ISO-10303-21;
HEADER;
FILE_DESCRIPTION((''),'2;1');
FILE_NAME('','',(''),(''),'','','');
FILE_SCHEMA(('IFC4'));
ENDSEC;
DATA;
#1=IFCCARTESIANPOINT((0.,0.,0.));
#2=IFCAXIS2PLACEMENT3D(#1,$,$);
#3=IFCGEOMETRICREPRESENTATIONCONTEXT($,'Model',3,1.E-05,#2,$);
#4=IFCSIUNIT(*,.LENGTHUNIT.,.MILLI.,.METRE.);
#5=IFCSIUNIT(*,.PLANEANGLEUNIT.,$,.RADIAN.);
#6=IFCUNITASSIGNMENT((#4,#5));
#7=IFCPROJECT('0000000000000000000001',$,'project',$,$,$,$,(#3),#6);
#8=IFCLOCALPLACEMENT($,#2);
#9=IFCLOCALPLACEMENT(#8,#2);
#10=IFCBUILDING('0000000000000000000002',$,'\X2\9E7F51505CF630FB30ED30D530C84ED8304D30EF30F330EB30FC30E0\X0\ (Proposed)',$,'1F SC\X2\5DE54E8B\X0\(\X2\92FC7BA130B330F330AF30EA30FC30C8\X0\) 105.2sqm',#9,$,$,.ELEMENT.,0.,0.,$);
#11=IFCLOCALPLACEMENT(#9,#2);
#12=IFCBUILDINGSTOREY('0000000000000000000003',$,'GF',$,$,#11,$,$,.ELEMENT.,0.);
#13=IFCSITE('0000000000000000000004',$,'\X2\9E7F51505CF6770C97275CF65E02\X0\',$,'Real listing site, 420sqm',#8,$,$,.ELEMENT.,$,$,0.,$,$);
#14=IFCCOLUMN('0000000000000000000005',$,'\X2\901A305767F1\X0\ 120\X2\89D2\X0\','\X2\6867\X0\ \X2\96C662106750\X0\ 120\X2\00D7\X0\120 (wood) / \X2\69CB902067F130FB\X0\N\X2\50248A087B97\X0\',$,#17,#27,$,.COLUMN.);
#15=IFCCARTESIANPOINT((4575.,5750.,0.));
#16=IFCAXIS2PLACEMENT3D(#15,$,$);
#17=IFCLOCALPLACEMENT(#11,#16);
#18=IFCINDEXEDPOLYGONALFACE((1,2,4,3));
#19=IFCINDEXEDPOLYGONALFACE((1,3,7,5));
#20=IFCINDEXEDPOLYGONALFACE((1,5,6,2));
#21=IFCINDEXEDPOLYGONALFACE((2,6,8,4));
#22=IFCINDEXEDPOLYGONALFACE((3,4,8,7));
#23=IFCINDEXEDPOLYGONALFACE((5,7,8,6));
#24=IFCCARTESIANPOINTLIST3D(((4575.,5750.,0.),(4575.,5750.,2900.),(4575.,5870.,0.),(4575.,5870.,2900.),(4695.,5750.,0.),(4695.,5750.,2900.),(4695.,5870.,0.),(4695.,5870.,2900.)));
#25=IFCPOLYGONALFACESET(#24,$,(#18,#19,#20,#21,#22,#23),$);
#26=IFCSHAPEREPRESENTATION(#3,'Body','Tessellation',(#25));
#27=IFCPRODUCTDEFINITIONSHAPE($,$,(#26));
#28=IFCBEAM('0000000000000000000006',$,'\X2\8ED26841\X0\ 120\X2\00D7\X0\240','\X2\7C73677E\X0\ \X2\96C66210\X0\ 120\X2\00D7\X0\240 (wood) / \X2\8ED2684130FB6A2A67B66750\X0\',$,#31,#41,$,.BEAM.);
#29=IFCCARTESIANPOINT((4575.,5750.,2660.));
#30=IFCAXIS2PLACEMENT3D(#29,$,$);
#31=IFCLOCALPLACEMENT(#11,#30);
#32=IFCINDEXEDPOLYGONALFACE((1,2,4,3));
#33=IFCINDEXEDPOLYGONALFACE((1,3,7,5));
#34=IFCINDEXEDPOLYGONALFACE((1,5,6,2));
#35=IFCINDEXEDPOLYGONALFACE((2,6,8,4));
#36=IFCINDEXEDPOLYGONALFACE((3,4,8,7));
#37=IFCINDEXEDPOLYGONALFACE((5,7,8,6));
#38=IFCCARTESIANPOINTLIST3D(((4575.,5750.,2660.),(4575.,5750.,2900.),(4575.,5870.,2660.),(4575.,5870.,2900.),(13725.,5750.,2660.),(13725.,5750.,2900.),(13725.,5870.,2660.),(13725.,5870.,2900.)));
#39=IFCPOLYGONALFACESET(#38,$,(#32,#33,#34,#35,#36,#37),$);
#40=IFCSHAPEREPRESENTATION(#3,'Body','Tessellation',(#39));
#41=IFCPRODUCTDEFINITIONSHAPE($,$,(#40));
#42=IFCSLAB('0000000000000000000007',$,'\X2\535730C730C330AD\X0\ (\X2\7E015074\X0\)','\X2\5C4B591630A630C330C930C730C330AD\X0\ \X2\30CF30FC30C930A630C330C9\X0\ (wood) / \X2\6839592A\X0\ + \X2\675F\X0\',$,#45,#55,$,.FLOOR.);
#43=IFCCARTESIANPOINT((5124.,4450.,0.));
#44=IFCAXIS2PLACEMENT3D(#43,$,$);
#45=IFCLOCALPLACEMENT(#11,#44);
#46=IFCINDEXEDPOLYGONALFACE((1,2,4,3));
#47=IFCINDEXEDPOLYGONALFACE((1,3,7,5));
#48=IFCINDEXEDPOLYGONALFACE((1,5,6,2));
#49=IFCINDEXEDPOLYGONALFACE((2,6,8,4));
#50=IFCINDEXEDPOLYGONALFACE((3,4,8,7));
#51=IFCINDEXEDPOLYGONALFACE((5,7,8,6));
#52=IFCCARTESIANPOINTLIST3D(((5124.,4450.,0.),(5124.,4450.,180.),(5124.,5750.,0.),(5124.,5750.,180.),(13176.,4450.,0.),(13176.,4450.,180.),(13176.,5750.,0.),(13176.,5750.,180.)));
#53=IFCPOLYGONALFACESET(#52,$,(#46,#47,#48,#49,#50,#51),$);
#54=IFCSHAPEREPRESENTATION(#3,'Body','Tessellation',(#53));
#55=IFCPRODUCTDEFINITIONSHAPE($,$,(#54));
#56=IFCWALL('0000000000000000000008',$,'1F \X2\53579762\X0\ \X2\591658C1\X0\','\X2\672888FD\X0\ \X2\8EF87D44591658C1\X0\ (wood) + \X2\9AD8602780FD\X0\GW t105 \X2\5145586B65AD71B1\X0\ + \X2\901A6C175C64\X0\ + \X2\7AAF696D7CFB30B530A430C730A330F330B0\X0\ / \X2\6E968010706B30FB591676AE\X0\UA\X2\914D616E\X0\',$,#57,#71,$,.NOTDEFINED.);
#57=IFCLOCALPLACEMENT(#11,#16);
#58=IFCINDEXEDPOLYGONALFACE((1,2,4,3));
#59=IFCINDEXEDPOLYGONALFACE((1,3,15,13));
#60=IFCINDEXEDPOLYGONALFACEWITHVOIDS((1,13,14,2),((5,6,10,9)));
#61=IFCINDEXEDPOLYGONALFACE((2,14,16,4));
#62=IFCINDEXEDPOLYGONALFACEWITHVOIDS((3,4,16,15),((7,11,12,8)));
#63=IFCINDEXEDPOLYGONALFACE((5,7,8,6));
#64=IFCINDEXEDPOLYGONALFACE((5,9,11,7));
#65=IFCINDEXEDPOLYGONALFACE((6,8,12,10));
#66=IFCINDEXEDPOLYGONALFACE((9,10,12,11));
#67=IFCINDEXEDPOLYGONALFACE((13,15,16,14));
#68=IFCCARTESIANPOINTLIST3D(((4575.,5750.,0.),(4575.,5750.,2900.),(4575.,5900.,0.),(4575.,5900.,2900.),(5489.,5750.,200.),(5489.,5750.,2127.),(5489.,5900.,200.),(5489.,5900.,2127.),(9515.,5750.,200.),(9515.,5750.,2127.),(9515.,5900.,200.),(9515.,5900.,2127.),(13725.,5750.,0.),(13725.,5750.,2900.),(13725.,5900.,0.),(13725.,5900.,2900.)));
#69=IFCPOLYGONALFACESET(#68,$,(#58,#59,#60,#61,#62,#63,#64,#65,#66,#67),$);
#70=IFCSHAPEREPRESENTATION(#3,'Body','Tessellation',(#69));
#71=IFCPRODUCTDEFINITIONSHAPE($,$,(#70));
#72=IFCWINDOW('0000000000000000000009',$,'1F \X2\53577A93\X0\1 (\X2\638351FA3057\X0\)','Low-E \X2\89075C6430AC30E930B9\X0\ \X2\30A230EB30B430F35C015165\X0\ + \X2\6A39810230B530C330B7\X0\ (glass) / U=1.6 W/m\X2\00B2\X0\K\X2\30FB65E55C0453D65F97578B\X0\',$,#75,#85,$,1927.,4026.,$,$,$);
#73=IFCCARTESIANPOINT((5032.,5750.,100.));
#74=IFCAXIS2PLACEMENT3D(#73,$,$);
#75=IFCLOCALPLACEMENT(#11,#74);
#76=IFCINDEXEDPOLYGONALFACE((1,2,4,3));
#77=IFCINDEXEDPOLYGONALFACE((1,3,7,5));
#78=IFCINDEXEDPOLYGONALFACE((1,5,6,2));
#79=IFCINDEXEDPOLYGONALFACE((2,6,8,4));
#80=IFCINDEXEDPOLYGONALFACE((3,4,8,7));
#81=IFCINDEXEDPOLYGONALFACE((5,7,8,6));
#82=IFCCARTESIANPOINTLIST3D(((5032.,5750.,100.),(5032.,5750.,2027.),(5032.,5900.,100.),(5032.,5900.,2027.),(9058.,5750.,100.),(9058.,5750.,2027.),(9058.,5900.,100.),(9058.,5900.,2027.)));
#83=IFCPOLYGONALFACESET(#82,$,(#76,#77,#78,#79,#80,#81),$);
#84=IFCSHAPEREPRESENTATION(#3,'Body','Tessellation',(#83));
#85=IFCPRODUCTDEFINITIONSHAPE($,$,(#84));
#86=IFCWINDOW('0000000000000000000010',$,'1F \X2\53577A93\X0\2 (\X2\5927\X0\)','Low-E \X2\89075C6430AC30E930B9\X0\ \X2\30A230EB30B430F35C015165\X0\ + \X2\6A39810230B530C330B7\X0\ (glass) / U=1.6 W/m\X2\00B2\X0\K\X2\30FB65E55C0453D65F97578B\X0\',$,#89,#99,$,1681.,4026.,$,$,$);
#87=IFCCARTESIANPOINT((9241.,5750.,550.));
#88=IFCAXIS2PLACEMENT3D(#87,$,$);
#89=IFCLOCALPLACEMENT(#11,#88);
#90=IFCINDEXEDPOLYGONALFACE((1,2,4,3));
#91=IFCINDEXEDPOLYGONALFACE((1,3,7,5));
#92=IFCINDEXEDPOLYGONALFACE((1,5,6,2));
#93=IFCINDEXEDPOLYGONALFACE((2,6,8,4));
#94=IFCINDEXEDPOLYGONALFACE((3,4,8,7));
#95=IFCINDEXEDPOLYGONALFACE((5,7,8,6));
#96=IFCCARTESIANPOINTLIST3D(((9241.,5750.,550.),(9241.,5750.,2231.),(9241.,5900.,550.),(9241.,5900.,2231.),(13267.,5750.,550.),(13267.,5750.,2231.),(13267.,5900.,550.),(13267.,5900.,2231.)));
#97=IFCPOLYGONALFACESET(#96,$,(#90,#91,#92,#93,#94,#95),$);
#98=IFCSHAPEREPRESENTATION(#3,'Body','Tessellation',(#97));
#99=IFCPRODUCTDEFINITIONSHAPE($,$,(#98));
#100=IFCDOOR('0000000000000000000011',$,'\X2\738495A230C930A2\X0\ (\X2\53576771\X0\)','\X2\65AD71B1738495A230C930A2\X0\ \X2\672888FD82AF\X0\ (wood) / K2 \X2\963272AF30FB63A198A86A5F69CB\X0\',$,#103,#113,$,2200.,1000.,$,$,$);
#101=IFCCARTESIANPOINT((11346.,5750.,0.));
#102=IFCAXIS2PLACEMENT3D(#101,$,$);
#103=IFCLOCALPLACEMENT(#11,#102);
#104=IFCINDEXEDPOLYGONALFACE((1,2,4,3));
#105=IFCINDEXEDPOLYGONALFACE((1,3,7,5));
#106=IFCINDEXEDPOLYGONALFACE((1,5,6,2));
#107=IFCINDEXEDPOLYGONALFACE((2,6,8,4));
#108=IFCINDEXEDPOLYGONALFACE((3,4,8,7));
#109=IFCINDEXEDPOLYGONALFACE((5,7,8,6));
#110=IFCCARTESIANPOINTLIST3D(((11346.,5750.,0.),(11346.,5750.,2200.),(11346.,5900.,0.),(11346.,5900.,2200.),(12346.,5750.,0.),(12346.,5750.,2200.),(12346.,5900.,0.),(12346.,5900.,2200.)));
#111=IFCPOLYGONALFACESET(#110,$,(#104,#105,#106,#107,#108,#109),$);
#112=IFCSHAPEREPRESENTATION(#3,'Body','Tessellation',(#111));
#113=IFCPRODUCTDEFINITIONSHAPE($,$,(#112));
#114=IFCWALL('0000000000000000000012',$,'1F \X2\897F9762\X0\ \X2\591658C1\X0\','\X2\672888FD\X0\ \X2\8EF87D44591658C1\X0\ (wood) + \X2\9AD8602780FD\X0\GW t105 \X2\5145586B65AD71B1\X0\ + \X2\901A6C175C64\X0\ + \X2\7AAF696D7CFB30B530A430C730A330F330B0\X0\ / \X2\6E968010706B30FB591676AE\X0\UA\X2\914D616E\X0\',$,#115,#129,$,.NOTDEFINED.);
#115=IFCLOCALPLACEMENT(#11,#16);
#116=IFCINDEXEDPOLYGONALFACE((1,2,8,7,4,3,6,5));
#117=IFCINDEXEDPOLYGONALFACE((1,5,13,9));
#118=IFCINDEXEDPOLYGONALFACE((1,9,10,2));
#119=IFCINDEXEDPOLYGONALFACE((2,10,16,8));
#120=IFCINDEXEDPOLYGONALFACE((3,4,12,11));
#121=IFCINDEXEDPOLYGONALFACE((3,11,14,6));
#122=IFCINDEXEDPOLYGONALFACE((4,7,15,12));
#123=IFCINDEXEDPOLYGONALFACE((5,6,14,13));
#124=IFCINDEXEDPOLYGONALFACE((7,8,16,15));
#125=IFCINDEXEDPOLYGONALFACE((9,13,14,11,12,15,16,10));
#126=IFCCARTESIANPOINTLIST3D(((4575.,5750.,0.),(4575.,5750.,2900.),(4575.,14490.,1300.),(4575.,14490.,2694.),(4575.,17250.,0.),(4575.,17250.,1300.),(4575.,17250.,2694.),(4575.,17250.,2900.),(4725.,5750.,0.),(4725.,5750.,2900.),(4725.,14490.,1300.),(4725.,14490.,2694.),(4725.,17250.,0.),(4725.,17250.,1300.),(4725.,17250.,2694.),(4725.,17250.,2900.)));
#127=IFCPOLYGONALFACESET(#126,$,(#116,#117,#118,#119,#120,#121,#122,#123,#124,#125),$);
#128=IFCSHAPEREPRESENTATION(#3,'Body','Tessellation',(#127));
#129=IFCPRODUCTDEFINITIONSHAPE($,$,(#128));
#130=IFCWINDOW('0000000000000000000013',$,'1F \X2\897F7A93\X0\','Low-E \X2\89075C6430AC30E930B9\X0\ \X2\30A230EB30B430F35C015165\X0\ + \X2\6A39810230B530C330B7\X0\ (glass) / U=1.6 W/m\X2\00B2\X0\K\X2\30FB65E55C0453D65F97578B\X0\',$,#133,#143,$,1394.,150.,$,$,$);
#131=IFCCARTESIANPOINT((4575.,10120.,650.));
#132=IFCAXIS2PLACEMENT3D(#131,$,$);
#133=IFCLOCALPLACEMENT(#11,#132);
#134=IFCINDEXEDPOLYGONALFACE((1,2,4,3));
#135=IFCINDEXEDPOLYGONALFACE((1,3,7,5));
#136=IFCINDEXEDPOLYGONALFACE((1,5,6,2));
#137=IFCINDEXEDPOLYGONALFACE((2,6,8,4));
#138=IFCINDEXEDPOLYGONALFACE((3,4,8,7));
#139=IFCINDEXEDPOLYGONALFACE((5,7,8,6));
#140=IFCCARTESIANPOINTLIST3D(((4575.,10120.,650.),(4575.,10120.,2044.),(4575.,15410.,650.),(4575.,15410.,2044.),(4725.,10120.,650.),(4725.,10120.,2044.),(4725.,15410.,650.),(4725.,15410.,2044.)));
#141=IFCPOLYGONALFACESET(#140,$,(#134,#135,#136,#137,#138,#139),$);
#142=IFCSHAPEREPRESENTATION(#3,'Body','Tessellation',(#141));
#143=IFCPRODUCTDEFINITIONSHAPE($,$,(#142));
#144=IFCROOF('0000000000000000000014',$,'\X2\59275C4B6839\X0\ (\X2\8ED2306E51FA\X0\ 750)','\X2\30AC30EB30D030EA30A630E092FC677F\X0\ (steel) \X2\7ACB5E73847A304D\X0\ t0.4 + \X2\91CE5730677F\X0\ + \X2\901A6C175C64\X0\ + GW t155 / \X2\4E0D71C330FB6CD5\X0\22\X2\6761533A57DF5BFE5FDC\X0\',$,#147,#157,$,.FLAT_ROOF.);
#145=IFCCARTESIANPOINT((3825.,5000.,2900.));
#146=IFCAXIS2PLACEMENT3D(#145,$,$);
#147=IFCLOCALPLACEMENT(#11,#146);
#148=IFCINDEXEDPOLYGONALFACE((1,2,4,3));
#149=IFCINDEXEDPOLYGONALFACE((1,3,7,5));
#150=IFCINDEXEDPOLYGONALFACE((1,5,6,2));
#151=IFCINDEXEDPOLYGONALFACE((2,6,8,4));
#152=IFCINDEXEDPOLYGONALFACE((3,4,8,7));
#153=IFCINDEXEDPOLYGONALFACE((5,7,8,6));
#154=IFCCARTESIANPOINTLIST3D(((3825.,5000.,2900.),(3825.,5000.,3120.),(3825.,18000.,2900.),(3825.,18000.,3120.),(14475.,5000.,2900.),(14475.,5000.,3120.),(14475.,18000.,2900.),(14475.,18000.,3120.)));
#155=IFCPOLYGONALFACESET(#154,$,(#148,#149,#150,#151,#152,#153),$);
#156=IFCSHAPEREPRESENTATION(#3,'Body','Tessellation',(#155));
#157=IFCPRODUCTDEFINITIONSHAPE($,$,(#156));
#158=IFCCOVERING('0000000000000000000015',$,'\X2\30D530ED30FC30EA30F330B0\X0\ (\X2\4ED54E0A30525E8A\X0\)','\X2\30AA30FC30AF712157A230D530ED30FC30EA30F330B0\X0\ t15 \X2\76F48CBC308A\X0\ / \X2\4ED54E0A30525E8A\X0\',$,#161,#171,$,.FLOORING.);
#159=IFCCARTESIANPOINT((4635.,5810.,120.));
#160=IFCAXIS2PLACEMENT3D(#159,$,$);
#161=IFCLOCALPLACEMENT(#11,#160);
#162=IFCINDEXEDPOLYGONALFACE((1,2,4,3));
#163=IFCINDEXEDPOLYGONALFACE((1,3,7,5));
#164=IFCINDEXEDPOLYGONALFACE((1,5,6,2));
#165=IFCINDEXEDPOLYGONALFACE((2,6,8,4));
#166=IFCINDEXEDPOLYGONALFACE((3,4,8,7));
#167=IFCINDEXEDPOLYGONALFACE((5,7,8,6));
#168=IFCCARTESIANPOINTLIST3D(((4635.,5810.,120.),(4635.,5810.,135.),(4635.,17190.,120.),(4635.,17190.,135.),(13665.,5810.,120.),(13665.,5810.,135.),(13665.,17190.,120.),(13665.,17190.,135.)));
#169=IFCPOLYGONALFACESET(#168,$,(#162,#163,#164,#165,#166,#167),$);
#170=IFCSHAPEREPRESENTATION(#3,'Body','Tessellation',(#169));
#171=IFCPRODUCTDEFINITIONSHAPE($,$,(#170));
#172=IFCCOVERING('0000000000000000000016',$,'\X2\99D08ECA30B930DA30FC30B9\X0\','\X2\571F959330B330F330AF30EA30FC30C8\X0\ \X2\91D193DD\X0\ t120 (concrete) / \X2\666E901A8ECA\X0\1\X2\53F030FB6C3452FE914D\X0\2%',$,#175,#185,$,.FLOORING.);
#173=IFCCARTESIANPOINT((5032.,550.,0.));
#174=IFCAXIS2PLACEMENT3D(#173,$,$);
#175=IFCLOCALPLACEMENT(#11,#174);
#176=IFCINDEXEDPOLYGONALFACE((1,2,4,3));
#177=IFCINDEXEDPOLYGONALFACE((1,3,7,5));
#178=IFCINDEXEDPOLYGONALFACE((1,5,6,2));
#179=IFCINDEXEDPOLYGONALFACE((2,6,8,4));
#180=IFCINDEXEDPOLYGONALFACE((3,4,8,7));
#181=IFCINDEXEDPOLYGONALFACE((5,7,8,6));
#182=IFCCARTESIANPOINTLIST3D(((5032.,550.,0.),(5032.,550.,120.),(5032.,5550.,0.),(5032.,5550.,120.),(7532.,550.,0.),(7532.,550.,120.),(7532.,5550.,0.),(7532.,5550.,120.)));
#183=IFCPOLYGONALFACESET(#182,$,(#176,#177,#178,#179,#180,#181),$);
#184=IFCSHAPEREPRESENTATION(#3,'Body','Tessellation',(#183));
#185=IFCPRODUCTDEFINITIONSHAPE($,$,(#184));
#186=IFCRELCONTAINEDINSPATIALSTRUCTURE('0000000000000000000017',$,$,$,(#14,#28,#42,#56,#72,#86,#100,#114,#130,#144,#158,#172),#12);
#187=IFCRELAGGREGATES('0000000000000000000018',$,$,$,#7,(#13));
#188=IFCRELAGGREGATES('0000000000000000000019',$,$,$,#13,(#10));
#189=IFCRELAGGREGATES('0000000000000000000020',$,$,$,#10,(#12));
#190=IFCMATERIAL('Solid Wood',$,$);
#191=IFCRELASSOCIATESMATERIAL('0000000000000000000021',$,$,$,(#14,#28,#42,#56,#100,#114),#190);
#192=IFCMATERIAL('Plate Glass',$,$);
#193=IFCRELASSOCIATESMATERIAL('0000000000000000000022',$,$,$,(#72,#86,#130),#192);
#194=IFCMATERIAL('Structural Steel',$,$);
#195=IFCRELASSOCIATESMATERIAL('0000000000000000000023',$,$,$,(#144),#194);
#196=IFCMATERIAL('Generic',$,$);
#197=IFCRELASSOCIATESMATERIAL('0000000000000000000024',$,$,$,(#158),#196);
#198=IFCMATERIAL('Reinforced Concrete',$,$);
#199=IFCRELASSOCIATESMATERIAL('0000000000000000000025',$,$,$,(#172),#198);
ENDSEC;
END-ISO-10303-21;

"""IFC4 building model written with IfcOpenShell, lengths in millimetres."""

from ifc_helpers import new_model, si_unit, frame, frame_2d, origin, place, context, project, spatial, rectangle, extrude, material, element, fill, save


model = new_model("IFC4")

# Units and contexts
model_context = context("Model", 3, precision=1e-05, world=origin())
ifc_project = project(units=[si_unit("LENGTHUNIT", "METRE", prefix="MILLI"), si_unit("PLANEANGLEUNIT", "RADIAN")], contexts=[model_context])

# Site, building, storey
site_placement = place(None, origin())
site = spatial("IfcSite", under=ifc_project, at=site_placement, Name="鹿児島県霧島市", ObjectType="Real listing site, 420sqm", CompositionType="ELEMENT", RefElevation=0.0)
building_placement = place(site_placement, origin())
building = spatial("IfcBuilding", under=site, at=building_placement, Name="鹿児島・ロフト付きワンルーム (Proposed)", ObjectType="1F SC工事(鋼管コンクリート) 105.2sqm", CompositionType="ELEMENT", ElevationOfRefHeight=0.0, ElevationOfTerrain=0.0)
storey_placement = place(building_placement, origin())
storey = spatial("IfcBuildingStorey", under=building, at=storey_placement, Name="GF", CompositionType="ELEMENT", Elevation=0.0)

# Column
ifc_material_1 = material(Name="Solid Wood")
column_1_placement = place(storey_placement, frame((4575.0, 5750.0, 0.0)))
element("IfcColumn", 1, at=column_1_placement, inside=storey, material=ifc_material_1, Name="通し柱 120角", Description="桧 集成材 120×120 (wood) / 構造柱・N値計算", PredefinedType="COLUMN", context=model_context, shape_type="SweptSolid", body=[
    extrude(rectangle(XDim=120.0, YDim=120.0, at=frame_2d((60.0, 60.0))), frame((4575.0, 5750.0, 0.0)), (0.0, 0.0, 1.0), 2900.0),
])

# Beam
beam_1_placement = place(storey_placement, frame((4575.0, 5750.0, 2660.0)))
element("IfcBeam", 2, at=beam_1_placement, inside=storey, material=ifc_material_1, Name="軒桁 120×240", Description="米松 集成 120×240 (wood) / 軒桁・横架材", PredefinedType="BEAM", context=model_context, shape_type="SweptSolid", body=[
    extrude(rectangle(XDim=9150.0, YDim=120.0, at=frame_2d((4575.0, 60.0))), frame((4575.0, 5750.0, 2660.0)), (0.0, 0.0, 1.0), 240.0),
])

# Slab
ifc_material_2 = material(Name="Reinforced Concrete")
slab_1_placement = place(storey_placement, frame((5124.0, 4450.0, 0.0)))
element("IfcSlab", 3, at=slab_1_placement, inside=storey, material=ifc_material_1, Name="南デッキ (縁側)", Description="屋外ウッドデッキ ハードウッド (wood) / 根太 + 束", PredefinedType="FLOOR", context=model_context, shape_type="SweptSolid", body=[
    extrude(rectangle(XDim=8052.0, YDim=1300.0, at=frame_2d((4026.0, 650.0))), frame((5124.0, 4450.0, 0.0)), (0.0, 0.0, 1.0), 180.0),
])

# Wall, openings, windows, door
wall_1_placement = place(storey_placement, frame((4575.0, 5750.0, 0.0)))
wall_1 = element("IfcWall", 4, at=wall_1_placement, inside=storey, material=ifc_material_1, Name="1F 南面 外壁", Description="木製 軸組外壁 (wood) + 高性能GW t105 充填断熱 + 通気層 + 窯業系サイディング / 準耐火・外皮UA配慮", PredefinedType="NOTDEFINED", context=model_context, shape_type="SweptSolid", body=[
    extrude(rectangle(XDim=9150.0, YDim=150.0, at=frame_2d((4575.0, 75.0))), frame((4575.0, 5750.0, 0.0)), (0.0, 0.0, 1.0), 2900.0),
])
opening_1_placement = place(storey_placement, frame((5032.0, 5750.0, 100.0)))
opening_1 = element("IfcOpeningElement", 5, at=opening_1_placement, cuts=wall_1, PredefinedType="NOTDEFINED", context=model_context, shape_type="SweptSolid", body=[
    extrude(rectangle(XDim=4026.0, YDim=150.0, at=frame_2d((2013.0, 75.0))), frame((5032.0, 5750.0, 100.0)), (0.0, 0.0, 1.0), 1927.0),
])
opening_2_placement = place(storey_placement, frame((9241.0, 5750.0, 550.0)))
opening_2 = element("IfcOpeningElement", 6, at=opening_2_placement, cuts=wall_1, PredefinedType="NOTDEFINED", context=model_context, shape_type="SweptSolid", body=[
    extrude(rectangle(XDim=4026.0, YDim=150.0, at=frame_2d((2013.0, 75.0))), frame((9241.0, 5750.0, 550.0)), (0.0, 0.0, 1.0), 1681.0),
])
opening_3_placement = place(storey_placement, frame((11346.0, 5750.0, 0.0)))
opening_3 = element("IfcOpeningElement", 7, at=opening_3_placement, cuts=wall_1, PredefinedType="NOTDEFINED", context=model_context, shape_type="SweptSolid", body=[
    extrude(rectangle(XDim=1000.0, YDim=150.0, at=frame_2d((500.0, 75.0))), frame((11346.0, 5750.0, 0.0)), (0.0, 0.0, 1.0), 2200.0),
])
ifc_material_3 = material(Name="Plate Glass")
window_1_placement = place(storey_placement, frame((5032.0, 5750.0, 100.0)))
window_1 = element("IfcWindow", 8, at=window_1_placement, inside=storey, material=ifc_material_3, Name="1F 南窓1 (掃出し)", Description="Low-E 複層ガラス アルゴン封入 + 樹脂サッシ (glass) / U=1.6 W/m²K・日射取得型", OverallHeight=1927.0, OverallWidth=4026.0, context=model_context, shape_type="SweptSolid", body=[
    extrude(rectangle(XDim=4026.0, YDim=150.0, at=frame_2d((2013.0, 75.0))), frame((5032.0, 5750.0, 100.0)), (0.0, 0.0, 1.0), 1927.0),
])
fill(opening_1, window_1)
window_2_placement = place(storey_placement, frame((9241.0, 5750.0, 550.0)))
window_2 = element("IfcWindow", 9, at=window_2_placement, inside=storey, material=ifc_material_3, Name="1F 南窓2 (大)", Description="Low-E 複層ガラス アルゴン封入 + 樹脂サッシ (glass) / U=1.6 W/m²K・日射取得型", OverallHeight=1681.0, OverallWidth=4026.0, context=model_context, shape_type="SweptSolid", body=[
    extrude(rectangle(XDim=4026.0, YDim=150.0, at=frame_2d((2013.0, 75.0))), frame((9241.0, 5750.0, 550.0)), (0.0, 0.0, 1.0), 1681.0),
])
fill(opening_2, window_2)
door_placement = place(storey_placement, frame((11346.0, 5750.0, 0.0)))
door = element("IfcDoor", 10, at=door_placement, inside=storey, material=ifc_material_1, Name="玄関ドア (南東)", Description="断熱玄関ドア 木製芯 (wood) / K2 防犯・採風機構", OverallHeight=2200.0, OverallWidth=1000.0, context=model_context, shape_type="SweptSolid", body=[
    extrude(rectangle(XDim=1000.0, YDim=150.0, at=frame_2d((500.0, 75.0))), frame((11346.0, 5750.0, 0.0)), (0.0, 0.0, 1.0), 2200.0),
])
fill(opening_3, door)

# Wall, opening, window
wall_2_placement = place(storey_placement, frame((4575.0, 5750.0, 0.0)))
wall_2 = element("IfcWall", 11, at=wall_2_placement, inside=storey, material=ifc_material_1, Name="1F 西面 外壁", Description="木製 軸組外壁 (wood) + 高性能GW t105 充填断熱 + 通気層 + 窯業系サイディング / 準耐火・外皮UA配慮", PredefinedType="NOTDEFINED", context=model_context, shape_type="SweptSolid", body=[
    extrude(rectangle(XDim=150.0, YDim=11500.0, at=frame_2d((75.0, 5750.0))), frame((4575.0, 5750.0, 0.0)), (0.0, 0.0, 1.0), 2900.0),
])
opening_4_placement = place(storey_placement, frame((4575.0, 10120.0, 650.0)))
opening_4 = element("IfcOpeningElement", 12, at=opening_4_placement, cuts=wall_2, PredefinedType="NOTDEFINED", context=model_context, shape_type="SweptSolid", body=[
    extrude(rectangle(XDim=150.0, YDim=5290.0, at=frame_2d((75.0, 2645.0))), frame((4575.0, 10120.0, 650.0)), (0.0, 0.0, 1.0), 1394.0),
])
window_3_placement = place(storey_placement, frame((4575.0, 10120.0, 650.0)))
window_3 = element("IfcWindow", 13, at=window_3_placement, inside=storey, material=ifc_material_3, Name="1F 西窓", Description="Low-E 複層ガラス アルゴン封入 + 樹脂サッシ (glass) / U=1.6 W/m²K・日射取得型", OverallHeight=1394.0, OverallWidth=150.0, context=model_context, shape_type="SweptSolid", body=[
    extrude(rectangle(XDim=150.0, YDim=5290.0, at=frame_2d((75.0, 2645.0))), frame((4575.0, 10120.0, 650.0)), (0.0, 0.0, 1.0), 1394.0),
])
fill(opening_4, window_3)

# Roof
ifc_material_4 = material(Name="Structural Steel")
roof_placement = place(storey_placement, frame((3825.0, 5000.0, 2900.0)))
element("IfcRoof", 14, at=roof_placement, inside=storey, material=ifc_material_4, Name="大屋根 (軒の出 750)", Description="ガルバリウム鋼板 (steel) 立平葺き t0.4 + 野地板 + 通気層 + GW t155 / 不燃・法22条区域対応", PredefinedType="FLAT_ROOF", context=model_context, shape_type="SweptSolid", body=[
    extrude(rectangle(XDim=10650.0, YDim=13000.0, at=frame_2d((5325.0, 6500.0))), frame((3825.0, 5000.0, 2900.0)), (0.0, 0.0, 1.0), 220.0),
])

# Coverings
ifc_material_5 = material(Name="Generic")
covering_1_placement = place(storey_placement, frame((4635.0, 5810.0, 120.0)))
element("IfcCovering", 15, at=covering_1_placement, inside=storey, material=ifc_material_5, Name="フローリング (仕上げ床)", Description="オーク無垢フローリング t15 直貼り / 仕上げ床", PredefinedType="FLOORING", context=model_context, shape_type="SweptSolid", body=[
    extrude(rectangle(XDim=9030.0, YDim=11380.0, at=frame_2d((4515.0, 5690.0))), frame((4635.0, 5810.0, 120.0)), (0.0, 0.0, 1.0), 15.0),
])
covering_2_placement = place(storey_placement, frame((5032.0, 550.0, 0.0)))
element("IfcCovering", 16, at=covering_2_placement, inside=storey, material=ifc_material_2, Name="駐車スペース", Description="土間コンクリート 金鏝 t120 (concrete) / 普通車1台・水勾配2%", PredefinedType="FLOORING", context=model_context, shape_type="SweptSolid", body=[
    extrude(rectangle(XDim=2500.0, YDim=5000.0, at=frame_2d((1250.0, 2500.0))), frame((5032.0, 550.0, 0.0)), (0.0, 0.0, 1.0), 120.0),
])

save(model, "model.ifc")
